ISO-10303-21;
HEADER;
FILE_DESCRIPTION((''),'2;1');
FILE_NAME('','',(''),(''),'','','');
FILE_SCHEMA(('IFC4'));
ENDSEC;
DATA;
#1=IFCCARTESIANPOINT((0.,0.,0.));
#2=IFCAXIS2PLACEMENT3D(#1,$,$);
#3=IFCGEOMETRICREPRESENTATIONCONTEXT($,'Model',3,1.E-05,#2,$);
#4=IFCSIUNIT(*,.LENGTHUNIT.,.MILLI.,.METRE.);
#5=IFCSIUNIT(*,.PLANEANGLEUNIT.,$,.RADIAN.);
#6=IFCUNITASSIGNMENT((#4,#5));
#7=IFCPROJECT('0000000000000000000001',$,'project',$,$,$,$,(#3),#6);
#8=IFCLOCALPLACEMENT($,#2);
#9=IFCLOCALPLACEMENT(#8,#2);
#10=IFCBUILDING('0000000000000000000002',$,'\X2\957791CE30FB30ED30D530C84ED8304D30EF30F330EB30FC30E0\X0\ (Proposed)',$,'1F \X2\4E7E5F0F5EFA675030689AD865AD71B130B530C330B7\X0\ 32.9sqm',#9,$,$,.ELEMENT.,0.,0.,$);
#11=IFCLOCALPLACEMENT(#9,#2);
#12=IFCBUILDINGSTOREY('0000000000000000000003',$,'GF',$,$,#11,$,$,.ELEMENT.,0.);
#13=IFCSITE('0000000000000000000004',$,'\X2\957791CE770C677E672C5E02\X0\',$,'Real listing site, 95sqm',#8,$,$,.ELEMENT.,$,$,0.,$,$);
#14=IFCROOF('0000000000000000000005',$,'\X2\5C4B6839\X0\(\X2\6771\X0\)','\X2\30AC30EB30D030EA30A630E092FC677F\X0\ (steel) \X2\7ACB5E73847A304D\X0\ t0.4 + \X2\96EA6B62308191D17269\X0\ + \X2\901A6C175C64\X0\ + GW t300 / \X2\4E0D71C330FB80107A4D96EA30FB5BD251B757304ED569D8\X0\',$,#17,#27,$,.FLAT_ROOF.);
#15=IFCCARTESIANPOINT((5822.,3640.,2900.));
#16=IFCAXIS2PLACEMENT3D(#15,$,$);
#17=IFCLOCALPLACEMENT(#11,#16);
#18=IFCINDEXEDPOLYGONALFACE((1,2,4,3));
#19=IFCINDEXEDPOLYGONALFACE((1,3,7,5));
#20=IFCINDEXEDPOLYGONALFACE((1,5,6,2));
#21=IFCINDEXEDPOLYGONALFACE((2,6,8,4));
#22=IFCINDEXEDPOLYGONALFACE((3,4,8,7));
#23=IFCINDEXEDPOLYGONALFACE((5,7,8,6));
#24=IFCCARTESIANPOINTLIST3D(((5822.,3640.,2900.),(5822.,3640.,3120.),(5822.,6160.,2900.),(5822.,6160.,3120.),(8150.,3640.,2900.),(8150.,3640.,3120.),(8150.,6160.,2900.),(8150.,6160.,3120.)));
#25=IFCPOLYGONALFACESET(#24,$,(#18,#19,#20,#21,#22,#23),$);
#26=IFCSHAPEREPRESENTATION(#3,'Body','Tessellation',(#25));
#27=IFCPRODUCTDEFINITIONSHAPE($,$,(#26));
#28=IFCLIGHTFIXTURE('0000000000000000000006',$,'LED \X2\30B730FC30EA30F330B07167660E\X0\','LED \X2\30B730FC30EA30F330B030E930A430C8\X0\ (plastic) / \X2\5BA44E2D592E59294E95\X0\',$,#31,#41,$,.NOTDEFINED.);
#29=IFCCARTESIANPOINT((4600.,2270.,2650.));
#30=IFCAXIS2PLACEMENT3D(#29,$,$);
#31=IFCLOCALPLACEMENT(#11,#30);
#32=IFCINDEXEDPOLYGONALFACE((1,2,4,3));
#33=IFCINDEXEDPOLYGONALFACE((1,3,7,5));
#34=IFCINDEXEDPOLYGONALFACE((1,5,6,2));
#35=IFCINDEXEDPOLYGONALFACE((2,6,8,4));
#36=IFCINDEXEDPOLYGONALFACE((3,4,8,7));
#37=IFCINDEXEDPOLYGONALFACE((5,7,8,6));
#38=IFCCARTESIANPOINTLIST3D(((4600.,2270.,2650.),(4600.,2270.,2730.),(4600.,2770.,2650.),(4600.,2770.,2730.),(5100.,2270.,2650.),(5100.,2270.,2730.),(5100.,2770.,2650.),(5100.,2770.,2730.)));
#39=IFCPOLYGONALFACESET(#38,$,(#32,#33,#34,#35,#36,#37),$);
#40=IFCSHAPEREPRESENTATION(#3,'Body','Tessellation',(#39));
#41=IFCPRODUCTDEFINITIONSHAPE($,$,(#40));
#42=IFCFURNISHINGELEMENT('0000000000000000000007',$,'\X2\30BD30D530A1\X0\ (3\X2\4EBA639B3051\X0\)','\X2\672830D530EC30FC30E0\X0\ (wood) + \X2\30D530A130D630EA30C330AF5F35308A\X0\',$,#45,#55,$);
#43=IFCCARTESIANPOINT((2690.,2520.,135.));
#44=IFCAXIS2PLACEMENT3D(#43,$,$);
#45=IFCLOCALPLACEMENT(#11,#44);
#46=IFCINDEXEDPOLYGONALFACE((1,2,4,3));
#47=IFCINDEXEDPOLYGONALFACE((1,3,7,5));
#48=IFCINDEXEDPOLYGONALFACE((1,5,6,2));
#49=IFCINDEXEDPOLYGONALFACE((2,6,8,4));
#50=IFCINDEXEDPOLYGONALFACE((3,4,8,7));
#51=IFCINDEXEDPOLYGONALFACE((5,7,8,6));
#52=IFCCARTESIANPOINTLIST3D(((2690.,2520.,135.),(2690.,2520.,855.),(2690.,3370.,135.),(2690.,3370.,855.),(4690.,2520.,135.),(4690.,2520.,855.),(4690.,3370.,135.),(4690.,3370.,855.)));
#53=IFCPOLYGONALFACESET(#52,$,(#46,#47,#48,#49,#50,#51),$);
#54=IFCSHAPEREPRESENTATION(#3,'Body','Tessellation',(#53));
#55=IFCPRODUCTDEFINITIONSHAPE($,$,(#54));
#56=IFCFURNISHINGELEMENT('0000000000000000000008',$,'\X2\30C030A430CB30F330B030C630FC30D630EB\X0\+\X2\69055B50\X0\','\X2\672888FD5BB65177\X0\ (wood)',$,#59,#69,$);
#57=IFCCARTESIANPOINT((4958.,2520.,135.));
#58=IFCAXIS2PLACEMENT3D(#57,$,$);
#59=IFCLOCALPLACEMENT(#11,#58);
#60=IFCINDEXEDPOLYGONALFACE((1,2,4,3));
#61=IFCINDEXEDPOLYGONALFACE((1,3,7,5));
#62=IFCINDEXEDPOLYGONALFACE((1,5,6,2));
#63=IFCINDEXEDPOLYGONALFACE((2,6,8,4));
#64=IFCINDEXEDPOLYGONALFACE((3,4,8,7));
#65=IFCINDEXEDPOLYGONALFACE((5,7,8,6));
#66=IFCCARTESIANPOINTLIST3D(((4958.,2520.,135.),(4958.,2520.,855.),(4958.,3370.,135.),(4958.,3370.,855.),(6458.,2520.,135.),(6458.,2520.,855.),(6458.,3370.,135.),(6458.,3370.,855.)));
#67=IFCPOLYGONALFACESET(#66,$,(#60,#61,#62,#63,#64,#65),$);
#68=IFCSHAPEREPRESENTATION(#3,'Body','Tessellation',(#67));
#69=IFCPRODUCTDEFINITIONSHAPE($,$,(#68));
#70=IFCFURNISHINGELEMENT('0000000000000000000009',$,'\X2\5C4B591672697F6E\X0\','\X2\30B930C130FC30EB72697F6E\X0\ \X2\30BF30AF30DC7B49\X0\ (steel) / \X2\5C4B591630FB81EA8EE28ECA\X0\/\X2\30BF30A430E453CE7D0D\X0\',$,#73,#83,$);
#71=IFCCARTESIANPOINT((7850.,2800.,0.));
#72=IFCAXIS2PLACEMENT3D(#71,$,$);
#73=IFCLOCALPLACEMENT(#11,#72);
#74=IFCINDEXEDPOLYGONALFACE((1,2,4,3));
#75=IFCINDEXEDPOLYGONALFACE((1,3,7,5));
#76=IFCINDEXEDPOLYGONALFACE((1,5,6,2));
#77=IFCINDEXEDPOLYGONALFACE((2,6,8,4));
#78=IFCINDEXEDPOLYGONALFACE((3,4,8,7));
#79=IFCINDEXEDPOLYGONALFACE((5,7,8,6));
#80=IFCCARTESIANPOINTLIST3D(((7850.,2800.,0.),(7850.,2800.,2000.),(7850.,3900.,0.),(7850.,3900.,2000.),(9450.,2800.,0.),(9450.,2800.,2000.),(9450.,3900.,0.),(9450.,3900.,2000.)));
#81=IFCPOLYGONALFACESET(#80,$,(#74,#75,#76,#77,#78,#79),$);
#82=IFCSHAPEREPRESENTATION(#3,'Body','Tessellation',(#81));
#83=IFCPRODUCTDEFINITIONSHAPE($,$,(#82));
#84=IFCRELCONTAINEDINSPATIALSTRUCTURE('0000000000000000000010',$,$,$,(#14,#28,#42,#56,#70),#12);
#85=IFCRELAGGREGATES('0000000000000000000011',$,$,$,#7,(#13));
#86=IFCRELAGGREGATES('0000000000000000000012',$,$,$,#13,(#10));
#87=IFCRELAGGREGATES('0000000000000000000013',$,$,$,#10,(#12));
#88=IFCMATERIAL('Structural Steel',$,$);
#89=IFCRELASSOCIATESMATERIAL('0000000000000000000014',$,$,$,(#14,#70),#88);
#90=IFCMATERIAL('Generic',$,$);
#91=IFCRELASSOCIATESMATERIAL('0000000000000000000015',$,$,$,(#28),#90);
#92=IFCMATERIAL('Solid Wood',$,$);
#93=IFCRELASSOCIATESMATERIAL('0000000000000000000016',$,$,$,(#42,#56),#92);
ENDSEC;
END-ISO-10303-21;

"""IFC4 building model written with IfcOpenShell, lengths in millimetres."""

from ifc_helpers import new_model, si_unit, frame, frame_2d, origin, place, context, project, spatial, rectangle, extrude, material, element, save


model = new_model("IFC4")

# Units and contexts
model_context = context("Model", 3, precision=1e-05, world=origin())
ifc_project = project(units=[si_unit("LENGTHUNIT", "METRE", prefix="MILLI"), si_unit("PLANEANGLEUNIT", "RADIAN")], contexts=[model_context])

# Site, building, storey
site_placement = place(None, origin())
site = spatial("IfcSite", under=ifc_project, at=site_placement, Name="長野県松本市", ObjectType="Real listing site, 95sqm", CompositionType="ELEMENT", RefElevation=0.0)
building_placement = place(site_placement, origin())
building = spatial("IfcBuilding", under=site, at=building_placement, Name="長野・ロフト付きワンルーム (Proposed)", ObjectType="1F 乾式建材と高断熱サッシ 32.9sqm", CompositionType="ELEMENT", ElevationOfRefHeight=0.0, ElevationOfTerrain=0.0)
storey_placement = place(building_placement, origin())
storey = spatial("IfcBuildingStorey", under=building, at=storey_placement, Name="GF", CompositionType="ELEMENT", Elevation=0.0)

# Shared definitions
ifc_material_1 = material(Name="Solid Wood")

# Roof
ifc_material_2 = material(Name="Structural Steel")
roof_1_placement = place(storey_placement, frame((5822.0, 3640.0, 2900.0)))
element("IfcRoof", 1, at=roof_1_placement, inside=storey, material=ifc_material_2, Name="屋根(東)", Description="ガルバリウム鋼板 (steel) 立平葺き t0.4 + 雪止め金物 + 通気層 + GW t300 / 不燃・耐積雪・寒冷地仕様", PredefinedType="FLAT_ROOF", context=model_context, shape_type="SweptSolid", body=[
    extrude(rectangle(XDim=2328.0, YDim=2520.0, at=frame_2d((1164.0, 1260.0))), frame((5822.0, 3640.0, 2900.0)), (0.0, 0.0, 1.0), 220.0),
])

# Light fixture
ifc_material_3 = material(Name="Generic")
light_fixture_placement = place(storey_placement, frame((4600.0, 2270.0, 2650.0)))
element("IfcLightFixture", 2, at=light_fixture_placement, inside=storey, material=ifc_material_3, Name="LED シーリング照明", Description="LED シーリングライト (plastic) / 室中央天井", PredefinedType="NOTDEFINED", context=model_context, shape_type="SweptSolid", body=[
    extrude(rectangle(XDim=500.0, YDim=500.0, at=frame_2d((250.0, 250.0))), frame((4600.0, 2270.0, 2650.0)), (0.0, 0.0, 1.0), 80.0),
])

# Furnishing elements
furnishing_1_placement = place(storey_placement, frame((2690.0, 2520.0, 135.0)))
element("IfcFurnishingElement", 3, at=furnishing_1_placement, inside=storey, material=ifc_material_1, Name="ソファ (3人掛け)", Description="木フレーム (wood) + ファブリック張り", context=model_context, shape_type="SweptSolid", body=[
    extrude(rectangle(XDim=2000.0, YDim=850.0, at=frame_2d((1000.0, 425.0))), frame((2690.0, 2520.0, 135.0)), (0.0, 0.0, 1.0), 720.0),
])
furnishing_2_placement = place(storey_placement, frame((4958.0, 2520.0, 135.0)))
element("IfcFurnishingElement", 4, at=furnishing_2_placement, inside=storey, material=ifc_material_1, Name="ダイニングテーブル+椅子", Description="木製家具 (wood)", context=model_context, shape_type="SweptSolid", body=[
    extrude(rectangle(XDim=1500.0, YDim=850.0, at=frame_2d((750.0, 425.0))), frame((4958.0, 2520.0, 135.0)), (0.0, 0.0, 1.0), 720.0),
])
furnishing_3_placement = place(storey_placement, frame((7850.0, 2800.0, 0.0)))
element("IfcFurnishingElement", 5, at=furnishing_3_placement, inside=storey, material=ifc_material_2, Name="屋外物置", Description="スチール物置 タクボ等 (steel) / 屋外・自転車/タイヤ収納", context=model_context, shape_type="SweptSolid", body=[
    extrude(rectangle(XDim=1600.0, YDim=1100.0, at=frame_2d((800.0, 550.0))), frame((7850.0, 2800.0, 0.0)), (0.0, 0.0, 1.0), 2000.0),
])

save(model, "model.ifc")
